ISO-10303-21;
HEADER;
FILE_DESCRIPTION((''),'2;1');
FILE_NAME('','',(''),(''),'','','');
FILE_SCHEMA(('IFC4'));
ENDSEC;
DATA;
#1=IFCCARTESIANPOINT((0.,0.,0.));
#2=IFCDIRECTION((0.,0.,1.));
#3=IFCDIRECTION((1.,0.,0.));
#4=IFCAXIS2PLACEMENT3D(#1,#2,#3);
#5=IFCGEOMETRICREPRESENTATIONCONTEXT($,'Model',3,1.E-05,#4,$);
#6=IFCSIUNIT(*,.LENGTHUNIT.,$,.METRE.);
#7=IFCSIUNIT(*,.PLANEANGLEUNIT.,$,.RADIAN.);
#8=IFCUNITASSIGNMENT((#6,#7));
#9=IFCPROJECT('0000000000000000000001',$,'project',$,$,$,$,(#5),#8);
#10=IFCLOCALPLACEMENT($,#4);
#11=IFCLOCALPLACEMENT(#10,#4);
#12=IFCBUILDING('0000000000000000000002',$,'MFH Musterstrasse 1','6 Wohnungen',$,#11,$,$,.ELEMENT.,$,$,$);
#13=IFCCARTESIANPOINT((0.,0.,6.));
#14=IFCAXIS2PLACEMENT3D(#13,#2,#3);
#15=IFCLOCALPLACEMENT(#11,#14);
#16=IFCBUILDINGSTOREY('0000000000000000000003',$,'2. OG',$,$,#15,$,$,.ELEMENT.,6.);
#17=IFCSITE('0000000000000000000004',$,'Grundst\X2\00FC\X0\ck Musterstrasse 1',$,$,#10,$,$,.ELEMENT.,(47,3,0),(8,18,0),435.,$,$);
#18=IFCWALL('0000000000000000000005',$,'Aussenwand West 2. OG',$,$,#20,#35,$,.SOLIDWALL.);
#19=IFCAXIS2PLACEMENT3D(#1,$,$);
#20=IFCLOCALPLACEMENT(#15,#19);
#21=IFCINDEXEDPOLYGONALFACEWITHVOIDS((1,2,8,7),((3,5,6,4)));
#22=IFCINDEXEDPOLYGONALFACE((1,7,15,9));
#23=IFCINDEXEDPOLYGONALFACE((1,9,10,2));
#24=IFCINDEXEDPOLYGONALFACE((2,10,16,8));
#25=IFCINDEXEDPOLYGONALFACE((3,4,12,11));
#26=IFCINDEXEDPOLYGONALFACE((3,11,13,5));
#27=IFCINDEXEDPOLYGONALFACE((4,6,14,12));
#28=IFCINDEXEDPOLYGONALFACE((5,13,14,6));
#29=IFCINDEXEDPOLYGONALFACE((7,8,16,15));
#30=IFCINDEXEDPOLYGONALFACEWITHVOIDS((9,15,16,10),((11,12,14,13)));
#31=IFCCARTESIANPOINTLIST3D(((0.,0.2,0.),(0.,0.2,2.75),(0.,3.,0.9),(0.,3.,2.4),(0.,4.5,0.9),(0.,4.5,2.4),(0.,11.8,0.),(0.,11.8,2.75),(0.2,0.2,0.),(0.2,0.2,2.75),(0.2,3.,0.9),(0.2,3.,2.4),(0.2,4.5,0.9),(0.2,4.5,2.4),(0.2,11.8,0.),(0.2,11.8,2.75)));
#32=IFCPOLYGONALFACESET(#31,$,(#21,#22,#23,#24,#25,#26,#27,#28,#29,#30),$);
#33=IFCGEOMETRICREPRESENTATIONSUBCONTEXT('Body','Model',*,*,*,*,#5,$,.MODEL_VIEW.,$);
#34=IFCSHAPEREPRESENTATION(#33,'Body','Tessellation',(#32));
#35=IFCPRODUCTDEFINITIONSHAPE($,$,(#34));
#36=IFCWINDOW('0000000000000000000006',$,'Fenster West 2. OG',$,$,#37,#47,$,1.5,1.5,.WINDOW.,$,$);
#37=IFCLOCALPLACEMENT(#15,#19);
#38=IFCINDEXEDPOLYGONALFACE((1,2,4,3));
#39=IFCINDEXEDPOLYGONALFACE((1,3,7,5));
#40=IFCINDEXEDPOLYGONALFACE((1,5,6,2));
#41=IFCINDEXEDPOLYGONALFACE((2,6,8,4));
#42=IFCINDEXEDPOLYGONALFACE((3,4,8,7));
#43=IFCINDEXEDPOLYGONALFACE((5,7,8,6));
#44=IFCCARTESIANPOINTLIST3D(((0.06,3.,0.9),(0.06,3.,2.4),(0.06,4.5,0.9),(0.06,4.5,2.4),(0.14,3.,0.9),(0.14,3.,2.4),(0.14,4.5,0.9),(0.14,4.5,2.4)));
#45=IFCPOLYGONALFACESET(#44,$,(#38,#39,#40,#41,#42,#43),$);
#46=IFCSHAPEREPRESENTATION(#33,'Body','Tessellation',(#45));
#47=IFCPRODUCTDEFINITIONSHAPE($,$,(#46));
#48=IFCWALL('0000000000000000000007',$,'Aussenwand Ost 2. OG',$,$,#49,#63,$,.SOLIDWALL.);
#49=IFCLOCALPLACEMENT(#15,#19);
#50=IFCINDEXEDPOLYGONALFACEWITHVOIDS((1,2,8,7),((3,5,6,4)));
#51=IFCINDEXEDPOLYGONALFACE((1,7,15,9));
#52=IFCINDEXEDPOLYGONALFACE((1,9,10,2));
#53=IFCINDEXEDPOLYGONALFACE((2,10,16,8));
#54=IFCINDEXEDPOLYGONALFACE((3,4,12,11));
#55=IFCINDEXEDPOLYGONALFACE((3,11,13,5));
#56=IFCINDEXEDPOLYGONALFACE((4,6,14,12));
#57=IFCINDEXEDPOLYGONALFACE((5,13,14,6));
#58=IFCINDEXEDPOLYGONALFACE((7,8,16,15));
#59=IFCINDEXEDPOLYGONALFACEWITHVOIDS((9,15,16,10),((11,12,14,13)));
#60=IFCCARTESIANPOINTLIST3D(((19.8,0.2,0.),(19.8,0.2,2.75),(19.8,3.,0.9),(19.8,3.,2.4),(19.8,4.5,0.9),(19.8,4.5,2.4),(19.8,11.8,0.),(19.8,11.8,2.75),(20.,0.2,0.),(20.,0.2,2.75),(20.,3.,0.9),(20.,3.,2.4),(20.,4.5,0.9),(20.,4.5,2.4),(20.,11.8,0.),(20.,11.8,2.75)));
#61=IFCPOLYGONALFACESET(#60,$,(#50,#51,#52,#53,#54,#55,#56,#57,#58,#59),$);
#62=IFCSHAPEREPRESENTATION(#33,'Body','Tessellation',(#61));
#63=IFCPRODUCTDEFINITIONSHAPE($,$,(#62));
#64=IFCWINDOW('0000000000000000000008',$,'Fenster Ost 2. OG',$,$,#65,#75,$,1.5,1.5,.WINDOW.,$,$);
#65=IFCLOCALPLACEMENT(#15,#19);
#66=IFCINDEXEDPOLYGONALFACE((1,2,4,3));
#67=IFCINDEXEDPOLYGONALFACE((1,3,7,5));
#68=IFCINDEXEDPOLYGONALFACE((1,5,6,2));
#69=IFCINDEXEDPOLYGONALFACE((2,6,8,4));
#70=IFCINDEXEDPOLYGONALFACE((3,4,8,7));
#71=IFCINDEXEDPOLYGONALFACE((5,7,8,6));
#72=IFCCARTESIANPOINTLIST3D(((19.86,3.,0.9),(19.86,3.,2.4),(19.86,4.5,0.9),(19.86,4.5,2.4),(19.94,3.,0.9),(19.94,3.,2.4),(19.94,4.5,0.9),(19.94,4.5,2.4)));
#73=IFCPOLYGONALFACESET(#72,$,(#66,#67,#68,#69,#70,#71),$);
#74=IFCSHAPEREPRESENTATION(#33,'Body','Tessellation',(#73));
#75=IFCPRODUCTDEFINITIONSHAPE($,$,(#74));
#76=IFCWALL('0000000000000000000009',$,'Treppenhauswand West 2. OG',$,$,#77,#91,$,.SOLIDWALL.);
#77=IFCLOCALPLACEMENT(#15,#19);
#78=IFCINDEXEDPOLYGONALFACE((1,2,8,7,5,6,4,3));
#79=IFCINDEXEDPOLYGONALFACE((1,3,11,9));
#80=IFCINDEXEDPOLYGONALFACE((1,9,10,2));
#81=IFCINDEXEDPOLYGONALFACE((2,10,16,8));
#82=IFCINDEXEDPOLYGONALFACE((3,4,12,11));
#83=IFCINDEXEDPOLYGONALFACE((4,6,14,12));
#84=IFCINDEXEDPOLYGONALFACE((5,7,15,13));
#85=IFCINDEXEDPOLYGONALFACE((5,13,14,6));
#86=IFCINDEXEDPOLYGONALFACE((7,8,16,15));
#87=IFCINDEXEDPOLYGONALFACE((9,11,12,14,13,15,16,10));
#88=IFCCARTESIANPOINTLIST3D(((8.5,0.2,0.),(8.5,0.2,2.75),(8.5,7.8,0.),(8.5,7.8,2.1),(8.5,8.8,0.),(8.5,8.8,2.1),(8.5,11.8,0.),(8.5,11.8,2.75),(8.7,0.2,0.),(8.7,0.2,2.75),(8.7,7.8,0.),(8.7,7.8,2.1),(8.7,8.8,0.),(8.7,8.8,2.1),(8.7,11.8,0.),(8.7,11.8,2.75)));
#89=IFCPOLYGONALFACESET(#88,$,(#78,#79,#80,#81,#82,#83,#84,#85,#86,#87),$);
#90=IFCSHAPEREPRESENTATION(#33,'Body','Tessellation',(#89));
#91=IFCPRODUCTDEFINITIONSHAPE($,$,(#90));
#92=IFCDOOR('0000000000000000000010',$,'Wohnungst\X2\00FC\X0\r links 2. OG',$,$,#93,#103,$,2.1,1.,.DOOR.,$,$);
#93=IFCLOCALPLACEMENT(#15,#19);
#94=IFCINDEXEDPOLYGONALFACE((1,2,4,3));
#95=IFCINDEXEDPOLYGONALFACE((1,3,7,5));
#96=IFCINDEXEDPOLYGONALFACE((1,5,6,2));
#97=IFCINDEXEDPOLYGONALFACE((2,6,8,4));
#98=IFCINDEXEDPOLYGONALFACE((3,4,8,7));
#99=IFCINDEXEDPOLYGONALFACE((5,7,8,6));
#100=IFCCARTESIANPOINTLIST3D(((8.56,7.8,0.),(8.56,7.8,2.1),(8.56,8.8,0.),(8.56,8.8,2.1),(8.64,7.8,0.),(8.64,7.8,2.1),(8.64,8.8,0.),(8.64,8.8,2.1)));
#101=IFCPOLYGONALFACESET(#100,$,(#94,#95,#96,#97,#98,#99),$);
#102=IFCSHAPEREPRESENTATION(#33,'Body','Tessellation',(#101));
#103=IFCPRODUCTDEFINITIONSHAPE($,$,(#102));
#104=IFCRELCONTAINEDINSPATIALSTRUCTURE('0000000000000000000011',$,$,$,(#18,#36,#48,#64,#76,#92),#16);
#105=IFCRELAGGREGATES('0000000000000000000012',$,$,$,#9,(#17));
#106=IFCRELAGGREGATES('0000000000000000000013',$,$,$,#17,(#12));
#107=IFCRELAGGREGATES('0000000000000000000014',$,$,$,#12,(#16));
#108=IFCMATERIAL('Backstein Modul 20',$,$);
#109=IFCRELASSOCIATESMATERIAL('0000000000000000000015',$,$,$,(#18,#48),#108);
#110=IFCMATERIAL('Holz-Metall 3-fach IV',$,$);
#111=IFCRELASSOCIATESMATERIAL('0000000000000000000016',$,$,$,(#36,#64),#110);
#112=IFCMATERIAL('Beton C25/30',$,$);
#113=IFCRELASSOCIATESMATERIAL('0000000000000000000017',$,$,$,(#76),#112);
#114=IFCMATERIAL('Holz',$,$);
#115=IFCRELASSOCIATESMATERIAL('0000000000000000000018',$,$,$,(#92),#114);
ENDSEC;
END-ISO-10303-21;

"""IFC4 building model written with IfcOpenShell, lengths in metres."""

from ifc_helpers import new_model, si_unit, frame, frame_2d, origin_with_axes, place, context, subcontext, project, spatial, rectangle, extrude, material, element, fill, save


model = new_model("IFC4")

# Units and contexts
model_context = context("Model", 3, precision=1e-05, world=origin_with_axes())
body_context = subcontext(model_context, "Body", "Model", "MODEL_VIEW")
ifc_project = project(units=[si_unit("LENGTHUNIT", "METRE"), si_unit("PLANEANGLEUNIT", "RADIAN")], contexts=[model_context])

# Site, building, storey
site_placement = place(None, origin_with_axes())
site = spatial("IfcSite", under=ifc_project, at=site_placement, Name="Grundstück Musterstrasse 1", CompositionType="ELEMENT", RefLatitude=(47, 3, 0), RefLongitude=(8, 18, 0), RefElevation=435.0)
building_placement = place(site_placement, origin_with_axes())
building = spatial("IfcBuilding", under=site, at=building_placement, Name="MFH Musterstrasse 1", Description="6 Wohnungen", CompositionType="ELEMENT")
storey_placement = place(building_placement, frame((0.0, 0.0, 6.0), z_axis=(0.0, 0.0, 1.0), x_axis=(1.0, 0.0, 0.0)))
storey = spatial("IfcBuildingStorey", under=building, at=storey_placement, Name="2. OG", CompositionType="ELEMENT", Elevation=6.0)

# Walls, openings, windows
ifc_material_1 = material(Name="Backstein Modul 20")
wall_1_placement = place(storey_placement, origin_with_axes())
wall_1 = element("IfcWall", 1, at=wall_1_placement, inside=storey, material=ifc_material_1, Name="Aussenwand West 2. OG", PredefinedType="SOLIDWALL", context=body_context, shape_type="SweptSolid", body=[
    extrude(rectangle(XDim=0.2, YDim=11.6, at=frame_2d((0.1, 5.8), x_axis=(1.0, 0.0))), frame((0.0, 0.2, 0.0), z_axis=(0.0, 0.0, 1.0), x_axis=(1.0, 0.0, 0.0)), (0.0, 0.0, 1.0), 2.75),
])
opening_1_placement = place(storey_placement, origin_with_axes())
element("IfcOpeningElement", 2, at=opening_1_placement, cuts=wall_1, PredefinedType="OPENING", context=body_context, shape_type="SweptSolid", body=[
    extrude(rectangle(XDim=0.3, YDim=1.5, at=frame_2d((0.15, 0.75), x_axis=(1.0, 0.0))), frame((-0.05, 3.0, 0.9), z_axis=(0.0, 0.0, 1.0), x_axis=(1.0, 0.0, 0.0)), (0.0, 0.0, 1.0), 1.5),
])
opening_2_placement = place(storey_placement, origin_with_axes())
opening_2 = element("IfcOpeningElement", 3, at=opening_2_placement, cuts=wall_1, PredefinedType="OPENING", context=body_context, shape_type="SweptSolid", body=[
    extrude(rectangle(XDim=0.22, YDim=1.5, at=frame_2d((0.11, 0.75), x_axis=(1.0, 0.0))), frame((-0.01, 3.0, 0.9), z_axis=(0.0, 0.0, 1.0), x_axis=(1.0, 0.0, 0.0)), (0.0, 0.0, 1.0), 1.5),
])
ifc_material_2 = material(Name="Holz-Metall 3-fach IV")
window_1_placement = place(storey_placement, origin_with_axes())
window_1 = element("IfcWindow", 4, at=window_1_placement, inside=storey, material=ifc_material_2, Name="Fenster West 2. OG", OverallHeight=1.5, OverallWidth=1.5, PredefinedType="WINDOW", context=body_context, shape_type="SweptSolid", body=[
    extrude(rectangle(XDim=0.08, YDim=1.5, at=frame_2d((0.04, 0.75), x_axis=(1.0, 0.0))), frame((0.06, 3.0, 0.9), z_axis=(0.0, 0.0, 1.0), x_axis=(1.0, 0.0, 0.0)), (0.0, 0.0, 1.0), 1.5),
])
fill(opening_2, window_1)
wall_2_placement = place(storey_placement, origin_with_axes())
wall_2 = element("IfcWall", 5, at=wall_2_placement, inside=storey, material=ifc_material_1, Name="Aussenwand Ost 2. OG", PredefinedType="SOLIDWALL", context=body_context, shape_type="SweptSolid", body=[
    extrude(rectangle(XDim=0.2, YDim=11.6, at=frame_2d((0.1, 5.8), x_axis=(1.0, 0.0))), frame((19.8, 0.2, 0.0), z_axis=(0.0, 0.0, 1.0), x_axis=(1.0, 0.0, 0.0)), (0.0, 0.0, 1.0), 2.75),
])
opening_3_placement = place(storey_placement, origin_with_axes())
element("IfcOpeningElement", 6, at=opening_3_placement, cuts=wall_2, PredefinedType="OPENING", context=body_context, shape_type="SweptSolid", body=[
    extrude(rectangle(XDim=0.3, YDim=1.5, at=frame_2d((0.15, 0.75), x_axis=(1.0, 0.0))), frame((19.75, 3.0, 0.9), z_axis=(0.0, 0.0, 1.0), x_axis=(1.0, 0.0, 0.0)), (0.0, 0.0, 1.0), 1.5),
])
opening_4_placement = place(storey_placement, origin_with_axes())
opening_4 = element("IfcOpeningElement", 7, at=opening_4_placement, cuts=wall_2, PredefinedType="OPENING", context=body_context, shape_type="SweptSolid", body=[
    extrude(rectangle(XDim=0.22, YDim=1.5, at=frame_2d((0.11, 0.75), x_axis=(1.0, 0.0))), frame((19.79, 3.0, 0.9), z_axis=(0.0, 0.0, 1.0), x_axis=(1.0, 0.0, 0.0)), (0.0, 0.0, 1.0), 1.5),
])
window_2_placement = place(storey_placement, origin_with_axes())
window_2 = element("IfcWindow", 8, at=window_2_placement, inside=storey, material=ifc_material_2, Name="Fenster Ost 2. OG", OverallHeight=1.5, OverallWidth=1.5, PredefinedType="WINDOW", context=body_context, shape_type="SweptSolid", body=[
    extrude(rectangle(XDim=0.08, YDim=1.5, at=frame_2d((0.04, 0.75), x_axis=(1.0, 0.0))), frame((19.86, 3.0, 0.9), z_axis=(0.0, 0.0, 1.0), x_axis=(1.0, 0.0, 0.0)), (0.0, 0.0, 1.0), 1.5),
])
fill(opening_4, window_2)

# Wall, openings, door
ifc_material_3 = material(Name="Beton C25/30")
wall_3_placement = place(storey_placement, origin_with_axes())
wall_3 = element("IfcWall", 9, at=wall_3_placement, inside=storey, material=ifc_material_3, Name="Treppenhauswand West 2. OG", PredefinedType="SOLIDWALL", context=body_context, shape_type="SweptSolid", body=[
    extrude(rectangle(XDim=0.2, YDim=11.6, at=frame_2d((0.1, 5.8), x_axis=(1.0, 0.0))), frame((8.5, 0.2, 0.0), z_axis=(0.0, 0.0, 1.0), x_axis=(1.0, 0.0, 0.0)), (0.0, 0.0, 1.0), 2.75),
])
opening_5_placement = place(storey_placement, origin_with_axes())
element("IfcOpeningElement", 10, at=opening_5_placement, cuts=wall_3, PredefinedType="OPENING", context=body_context, shape_type="SweptSolid", body=[
    extrude(rectangle(XDim=0.3, YDim=1.0, at=frame_2d((0.15, 0.5), x_axis=(1.0, 0.0))), frame((8.45, 7.8, 0.0), z_axis=(0.0, 0.0, 1.0), x_axis=(1.0, 0.0, 0.0)), (0.0, 0.0, 1.0), 2.1),
])
opening_6_placement = place(storey_placement, origin_with_axes())
opening_6 = element("IfcOpeningElement", 11, at=opening_6_placement, cuts=wall_3, PredefinedType="OPENING", context=body_context, shape_type="SweptSolid", body=[
    extrude(rectangle(XDim=0.22, YDim=1.0, at=frame_2d((0.11, 0.5), x_axis=(1.0, 0.0))), frame((8.49, 7.8, 0.0), z_axis=(0.0, 0.0, 1.0), x_axis=(1.0, 0.0, 0.0)), (0.0, 0.0, 1.0), 2.1),
])
ifc_material_4 = material(Name="Holz")
door_placement = place(storey_placement, origin_with_axes())
door = element("IfcDoor", 12, at=door_placement, inside=storey, material=ifc_material_4, Name="Wohnungstür links 2. OG", OverallHeight=2.1, OverallWidth=1.0, PredefinedType="DOOR", context=body_context, shape_type="SweptSolid", body=[
    extrude(rectangle(XDim=0.08, YDim=1.0, at=frame_2d((0.04, 0.5), x_axis=(1.0, 0.0))), frame((8.56, 7.8, 0.0), z_axis=(0.0, 0.0, 1.0), x_axis=(1.0, 0.0, 0.0)), (0.0, 0.0, 1.0), 2.1),
])
fill(opening_6, door)

save(model, "model.ifc")
